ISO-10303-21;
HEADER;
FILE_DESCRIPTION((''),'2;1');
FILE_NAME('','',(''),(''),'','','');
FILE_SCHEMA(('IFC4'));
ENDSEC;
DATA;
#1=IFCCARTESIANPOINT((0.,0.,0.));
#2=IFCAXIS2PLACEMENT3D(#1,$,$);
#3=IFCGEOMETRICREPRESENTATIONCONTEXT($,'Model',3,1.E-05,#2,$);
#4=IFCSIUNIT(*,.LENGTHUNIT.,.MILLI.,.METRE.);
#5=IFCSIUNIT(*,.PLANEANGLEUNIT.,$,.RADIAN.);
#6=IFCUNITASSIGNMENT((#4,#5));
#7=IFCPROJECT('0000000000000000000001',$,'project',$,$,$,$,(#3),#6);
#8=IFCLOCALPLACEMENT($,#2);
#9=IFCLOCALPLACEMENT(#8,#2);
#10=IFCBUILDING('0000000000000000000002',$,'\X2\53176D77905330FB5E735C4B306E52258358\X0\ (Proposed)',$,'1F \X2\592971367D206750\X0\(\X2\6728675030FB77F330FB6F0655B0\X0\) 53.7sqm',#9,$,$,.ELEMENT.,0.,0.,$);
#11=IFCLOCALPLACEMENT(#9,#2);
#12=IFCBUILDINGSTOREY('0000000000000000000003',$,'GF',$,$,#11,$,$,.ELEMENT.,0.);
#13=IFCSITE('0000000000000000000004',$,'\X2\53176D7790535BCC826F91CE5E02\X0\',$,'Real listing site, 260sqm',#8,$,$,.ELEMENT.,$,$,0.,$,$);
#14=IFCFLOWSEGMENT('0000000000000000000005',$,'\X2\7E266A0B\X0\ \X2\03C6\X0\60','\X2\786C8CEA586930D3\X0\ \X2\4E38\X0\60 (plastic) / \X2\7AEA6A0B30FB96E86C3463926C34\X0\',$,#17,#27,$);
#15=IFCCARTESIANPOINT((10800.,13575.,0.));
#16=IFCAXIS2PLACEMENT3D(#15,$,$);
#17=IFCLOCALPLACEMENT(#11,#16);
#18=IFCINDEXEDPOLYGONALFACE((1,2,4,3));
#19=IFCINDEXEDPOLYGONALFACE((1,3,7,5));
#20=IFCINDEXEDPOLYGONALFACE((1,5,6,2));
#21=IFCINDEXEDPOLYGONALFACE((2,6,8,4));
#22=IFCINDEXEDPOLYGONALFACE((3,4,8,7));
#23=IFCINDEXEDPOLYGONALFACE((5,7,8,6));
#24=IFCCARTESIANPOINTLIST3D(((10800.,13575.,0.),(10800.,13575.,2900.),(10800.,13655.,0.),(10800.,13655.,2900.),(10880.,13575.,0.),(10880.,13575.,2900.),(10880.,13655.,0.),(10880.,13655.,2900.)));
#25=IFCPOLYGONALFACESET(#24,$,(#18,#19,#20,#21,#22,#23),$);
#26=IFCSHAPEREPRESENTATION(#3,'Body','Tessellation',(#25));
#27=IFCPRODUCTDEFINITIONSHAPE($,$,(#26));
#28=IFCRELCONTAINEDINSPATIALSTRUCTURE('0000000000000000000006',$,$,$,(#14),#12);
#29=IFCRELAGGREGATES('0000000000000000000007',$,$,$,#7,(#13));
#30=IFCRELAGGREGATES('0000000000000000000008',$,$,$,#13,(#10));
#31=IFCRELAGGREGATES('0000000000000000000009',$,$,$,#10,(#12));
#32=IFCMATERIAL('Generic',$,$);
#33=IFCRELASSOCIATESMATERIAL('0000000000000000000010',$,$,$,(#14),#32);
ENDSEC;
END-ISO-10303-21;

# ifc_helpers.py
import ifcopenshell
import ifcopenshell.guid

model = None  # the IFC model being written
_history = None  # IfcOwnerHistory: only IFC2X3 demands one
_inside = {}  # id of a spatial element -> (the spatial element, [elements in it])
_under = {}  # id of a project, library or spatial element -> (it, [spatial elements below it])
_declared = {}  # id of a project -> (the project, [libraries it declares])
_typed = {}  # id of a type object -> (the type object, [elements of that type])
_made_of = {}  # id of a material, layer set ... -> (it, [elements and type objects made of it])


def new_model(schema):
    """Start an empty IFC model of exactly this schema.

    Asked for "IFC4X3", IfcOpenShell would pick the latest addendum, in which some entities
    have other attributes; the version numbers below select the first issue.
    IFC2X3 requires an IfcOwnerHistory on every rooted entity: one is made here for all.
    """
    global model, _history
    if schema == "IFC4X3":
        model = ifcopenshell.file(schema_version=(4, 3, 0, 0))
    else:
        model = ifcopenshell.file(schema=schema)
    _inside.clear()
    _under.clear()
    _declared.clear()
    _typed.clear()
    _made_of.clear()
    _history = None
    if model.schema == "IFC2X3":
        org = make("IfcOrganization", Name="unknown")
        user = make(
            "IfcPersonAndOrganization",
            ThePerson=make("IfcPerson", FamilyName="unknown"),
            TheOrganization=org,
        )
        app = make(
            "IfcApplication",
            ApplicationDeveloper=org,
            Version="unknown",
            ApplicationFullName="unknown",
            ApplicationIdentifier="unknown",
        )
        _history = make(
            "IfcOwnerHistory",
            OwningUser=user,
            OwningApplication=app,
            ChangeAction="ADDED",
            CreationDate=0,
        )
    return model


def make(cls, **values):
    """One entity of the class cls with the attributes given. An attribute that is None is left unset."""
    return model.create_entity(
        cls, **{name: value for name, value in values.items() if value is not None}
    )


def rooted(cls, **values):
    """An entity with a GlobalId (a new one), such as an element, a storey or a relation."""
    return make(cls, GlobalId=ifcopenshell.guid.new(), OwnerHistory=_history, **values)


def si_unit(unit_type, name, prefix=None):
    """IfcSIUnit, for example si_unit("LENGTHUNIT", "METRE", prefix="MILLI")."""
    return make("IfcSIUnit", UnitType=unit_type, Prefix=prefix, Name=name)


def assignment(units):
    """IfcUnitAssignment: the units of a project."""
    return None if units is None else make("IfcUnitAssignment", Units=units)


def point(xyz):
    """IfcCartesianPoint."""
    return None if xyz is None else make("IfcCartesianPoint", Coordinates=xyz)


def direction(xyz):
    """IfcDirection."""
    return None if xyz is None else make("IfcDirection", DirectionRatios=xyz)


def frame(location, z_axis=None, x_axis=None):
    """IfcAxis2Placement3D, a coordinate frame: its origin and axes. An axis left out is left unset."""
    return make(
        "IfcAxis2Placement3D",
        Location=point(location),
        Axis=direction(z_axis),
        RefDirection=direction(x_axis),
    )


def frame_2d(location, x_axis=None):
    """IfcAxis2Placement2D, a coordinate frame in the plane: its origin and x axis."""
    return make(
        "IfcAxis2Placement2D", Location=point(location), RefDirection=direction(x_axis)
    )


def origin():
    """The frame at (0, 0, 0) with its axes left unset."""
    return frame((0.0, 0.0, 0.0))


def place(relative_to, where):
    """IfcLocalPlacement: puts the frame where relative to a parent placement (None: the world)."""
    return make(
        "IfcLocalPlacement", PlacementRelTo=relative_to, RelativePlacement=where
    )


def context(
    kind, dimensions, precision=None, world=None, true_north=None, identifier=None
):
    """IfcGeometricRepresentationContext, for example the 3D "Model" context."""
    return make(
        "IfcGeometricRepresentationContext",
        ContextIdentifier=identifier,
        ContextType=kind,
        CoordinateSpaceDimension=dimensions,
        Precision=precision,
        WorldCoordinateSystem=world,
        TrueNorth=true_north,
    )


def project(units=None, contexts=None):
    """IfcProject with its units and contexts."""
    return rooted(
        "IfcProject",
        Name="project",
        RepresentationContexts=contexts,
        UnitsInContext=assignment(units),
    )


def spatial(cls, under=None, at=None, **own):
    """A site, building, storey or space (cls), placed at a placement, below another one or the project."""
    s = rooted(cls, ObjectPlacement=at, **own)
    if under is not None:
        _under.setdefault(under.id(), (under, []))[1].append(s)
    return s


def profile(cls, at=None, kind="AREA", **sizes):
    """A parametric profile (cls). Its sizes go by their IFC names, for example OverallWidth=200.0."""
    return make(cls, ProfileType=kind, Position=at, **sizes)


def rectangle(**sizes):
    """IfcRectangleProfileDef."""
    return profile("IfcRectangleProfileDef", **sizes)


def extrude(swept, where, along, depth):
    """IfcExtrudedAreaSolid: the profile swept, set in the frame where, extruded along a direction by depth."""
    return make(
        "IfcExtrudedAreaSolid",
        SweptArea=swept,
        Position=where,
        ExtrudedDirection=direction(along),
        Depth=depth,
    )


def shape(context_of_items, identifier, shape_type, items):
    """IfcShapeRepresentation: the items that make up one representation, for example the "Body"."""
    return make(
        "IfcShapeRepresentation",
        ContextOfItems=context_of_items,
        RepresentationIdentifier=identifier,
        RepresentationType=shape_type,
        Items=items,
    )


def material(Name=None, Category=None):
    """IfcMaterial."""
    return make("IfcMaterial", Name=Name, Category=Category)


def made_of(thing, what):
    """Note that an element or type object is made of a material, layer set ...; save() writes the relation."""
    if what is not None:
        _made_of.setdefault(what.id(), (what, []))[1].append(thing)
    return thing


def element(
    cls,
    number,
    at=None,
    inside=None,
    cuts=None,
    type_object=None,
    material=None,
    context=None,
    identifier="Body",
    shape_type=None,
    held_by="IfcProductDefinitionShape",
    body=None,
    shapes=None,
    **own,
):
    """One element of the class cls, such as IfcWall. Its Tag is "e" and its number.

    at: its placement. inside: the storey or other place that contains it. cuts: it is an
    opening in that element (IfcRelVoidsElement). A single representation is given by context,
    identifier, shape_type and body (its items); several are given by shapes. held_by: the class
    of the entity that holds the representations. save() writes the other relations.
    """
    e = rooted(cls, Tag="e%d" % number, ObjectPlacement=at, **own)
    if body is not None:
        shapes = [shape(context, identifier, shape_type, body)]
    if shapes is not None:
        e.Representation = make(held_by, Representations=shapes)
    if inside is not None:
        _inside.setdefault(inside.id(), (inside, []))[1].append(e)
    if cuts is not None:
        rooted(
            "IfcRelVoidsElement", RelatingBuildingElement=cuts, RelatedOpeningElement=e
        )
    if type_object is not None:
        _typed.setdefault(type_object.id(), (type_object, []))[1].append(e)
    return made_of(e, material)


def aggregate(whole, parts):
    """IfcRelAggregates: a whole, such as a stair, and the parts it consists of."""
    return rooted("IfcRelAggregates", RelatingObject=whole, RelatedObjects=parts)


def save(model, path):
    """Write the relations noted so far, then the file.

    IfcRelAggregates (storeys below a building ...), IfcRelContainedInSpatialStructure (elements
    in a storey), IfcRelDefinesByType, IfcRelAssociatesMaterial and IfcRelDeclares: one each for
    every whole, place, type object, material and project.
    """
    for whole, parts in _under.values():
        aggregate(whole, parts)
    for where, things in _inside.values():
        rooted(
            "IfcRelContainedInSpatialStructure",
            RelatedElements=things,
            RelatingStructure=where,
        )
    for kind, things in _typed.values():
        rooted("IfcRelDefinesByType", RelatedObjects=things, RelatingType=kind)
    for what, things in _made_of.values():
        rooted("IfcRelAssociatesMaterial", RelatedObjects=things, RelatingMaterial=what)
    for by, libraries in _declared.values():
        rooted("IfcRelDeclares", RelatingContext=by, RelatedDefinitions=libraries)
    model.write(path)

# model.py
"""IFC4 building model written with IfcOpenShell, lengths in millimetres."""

from ifc_helpers import new_model, si_unit, frame, frame_2d, origin, place, context, project, spatial, rectangle, extrude, material, element, save


model = new_model("IFC4")

# Units and contexts
model_context = context("Model", 3, precision=1e-05, world=origin())
ifc_project = project(units=[si_unit("LENGTHUNIT", "METRE", prefix="MILLI"), si_unit("PLANEANGLEUNIT", "RADIAN")], contexts=[model_context])

# Site, building, storey
site_placement = place(None, origin())
site = spatial("IfcSite", under=ifc_project, at=site_placement, Name="北海道富良野市", ObjectType="Real listing site, 260sqm", CompositionType="ELEMENT", RefElevation=0.0)
building_placement = place(site_placement, origin())
building = spatial("IfcBuilding", under=site, at=building_placement, Name="北海道・平屋の別荘 (Proposed)", ObjectType="1F 天然素材(木材・石・漆喰) 53.7sqm", CompositionType="ELEMENT", ElevationOfRefHeight=0.0, ElevationOfTerrain=0.0)
storey_placement = place(building_placement, origin())
storey = spatial("IfcBuildingStorey", under=building, at=storey_placement, Name="GF", CompositionType="ELEMENT", Elevation=0.0)

# Shared definitions
ifc_material_1 = material(Name="Generic")

# Flow segment
flow_segment_placement = place(storey_placement, frame((10800.0, 13575.0, 0.0)))
element("IfcFlowSegment", 1, at=flow_segment_placement, inside=storey, material=ifc_material_1, Name="縦樋 φ60", Description="硬質塩ビ 丸60 (plastic) / 竪樋・雨水排水", context=model_context, shape_type="SweptSolid", body=[
    extrude(rectangle(XDim=80.0, YDim=80.0, at=frame_2d((40.0, 40.0))), frame((10800.0, 13575.0, 0.0)), (0.0, 0.0, 1.0), 2900.0),
])

save(model, "model.ifc")
